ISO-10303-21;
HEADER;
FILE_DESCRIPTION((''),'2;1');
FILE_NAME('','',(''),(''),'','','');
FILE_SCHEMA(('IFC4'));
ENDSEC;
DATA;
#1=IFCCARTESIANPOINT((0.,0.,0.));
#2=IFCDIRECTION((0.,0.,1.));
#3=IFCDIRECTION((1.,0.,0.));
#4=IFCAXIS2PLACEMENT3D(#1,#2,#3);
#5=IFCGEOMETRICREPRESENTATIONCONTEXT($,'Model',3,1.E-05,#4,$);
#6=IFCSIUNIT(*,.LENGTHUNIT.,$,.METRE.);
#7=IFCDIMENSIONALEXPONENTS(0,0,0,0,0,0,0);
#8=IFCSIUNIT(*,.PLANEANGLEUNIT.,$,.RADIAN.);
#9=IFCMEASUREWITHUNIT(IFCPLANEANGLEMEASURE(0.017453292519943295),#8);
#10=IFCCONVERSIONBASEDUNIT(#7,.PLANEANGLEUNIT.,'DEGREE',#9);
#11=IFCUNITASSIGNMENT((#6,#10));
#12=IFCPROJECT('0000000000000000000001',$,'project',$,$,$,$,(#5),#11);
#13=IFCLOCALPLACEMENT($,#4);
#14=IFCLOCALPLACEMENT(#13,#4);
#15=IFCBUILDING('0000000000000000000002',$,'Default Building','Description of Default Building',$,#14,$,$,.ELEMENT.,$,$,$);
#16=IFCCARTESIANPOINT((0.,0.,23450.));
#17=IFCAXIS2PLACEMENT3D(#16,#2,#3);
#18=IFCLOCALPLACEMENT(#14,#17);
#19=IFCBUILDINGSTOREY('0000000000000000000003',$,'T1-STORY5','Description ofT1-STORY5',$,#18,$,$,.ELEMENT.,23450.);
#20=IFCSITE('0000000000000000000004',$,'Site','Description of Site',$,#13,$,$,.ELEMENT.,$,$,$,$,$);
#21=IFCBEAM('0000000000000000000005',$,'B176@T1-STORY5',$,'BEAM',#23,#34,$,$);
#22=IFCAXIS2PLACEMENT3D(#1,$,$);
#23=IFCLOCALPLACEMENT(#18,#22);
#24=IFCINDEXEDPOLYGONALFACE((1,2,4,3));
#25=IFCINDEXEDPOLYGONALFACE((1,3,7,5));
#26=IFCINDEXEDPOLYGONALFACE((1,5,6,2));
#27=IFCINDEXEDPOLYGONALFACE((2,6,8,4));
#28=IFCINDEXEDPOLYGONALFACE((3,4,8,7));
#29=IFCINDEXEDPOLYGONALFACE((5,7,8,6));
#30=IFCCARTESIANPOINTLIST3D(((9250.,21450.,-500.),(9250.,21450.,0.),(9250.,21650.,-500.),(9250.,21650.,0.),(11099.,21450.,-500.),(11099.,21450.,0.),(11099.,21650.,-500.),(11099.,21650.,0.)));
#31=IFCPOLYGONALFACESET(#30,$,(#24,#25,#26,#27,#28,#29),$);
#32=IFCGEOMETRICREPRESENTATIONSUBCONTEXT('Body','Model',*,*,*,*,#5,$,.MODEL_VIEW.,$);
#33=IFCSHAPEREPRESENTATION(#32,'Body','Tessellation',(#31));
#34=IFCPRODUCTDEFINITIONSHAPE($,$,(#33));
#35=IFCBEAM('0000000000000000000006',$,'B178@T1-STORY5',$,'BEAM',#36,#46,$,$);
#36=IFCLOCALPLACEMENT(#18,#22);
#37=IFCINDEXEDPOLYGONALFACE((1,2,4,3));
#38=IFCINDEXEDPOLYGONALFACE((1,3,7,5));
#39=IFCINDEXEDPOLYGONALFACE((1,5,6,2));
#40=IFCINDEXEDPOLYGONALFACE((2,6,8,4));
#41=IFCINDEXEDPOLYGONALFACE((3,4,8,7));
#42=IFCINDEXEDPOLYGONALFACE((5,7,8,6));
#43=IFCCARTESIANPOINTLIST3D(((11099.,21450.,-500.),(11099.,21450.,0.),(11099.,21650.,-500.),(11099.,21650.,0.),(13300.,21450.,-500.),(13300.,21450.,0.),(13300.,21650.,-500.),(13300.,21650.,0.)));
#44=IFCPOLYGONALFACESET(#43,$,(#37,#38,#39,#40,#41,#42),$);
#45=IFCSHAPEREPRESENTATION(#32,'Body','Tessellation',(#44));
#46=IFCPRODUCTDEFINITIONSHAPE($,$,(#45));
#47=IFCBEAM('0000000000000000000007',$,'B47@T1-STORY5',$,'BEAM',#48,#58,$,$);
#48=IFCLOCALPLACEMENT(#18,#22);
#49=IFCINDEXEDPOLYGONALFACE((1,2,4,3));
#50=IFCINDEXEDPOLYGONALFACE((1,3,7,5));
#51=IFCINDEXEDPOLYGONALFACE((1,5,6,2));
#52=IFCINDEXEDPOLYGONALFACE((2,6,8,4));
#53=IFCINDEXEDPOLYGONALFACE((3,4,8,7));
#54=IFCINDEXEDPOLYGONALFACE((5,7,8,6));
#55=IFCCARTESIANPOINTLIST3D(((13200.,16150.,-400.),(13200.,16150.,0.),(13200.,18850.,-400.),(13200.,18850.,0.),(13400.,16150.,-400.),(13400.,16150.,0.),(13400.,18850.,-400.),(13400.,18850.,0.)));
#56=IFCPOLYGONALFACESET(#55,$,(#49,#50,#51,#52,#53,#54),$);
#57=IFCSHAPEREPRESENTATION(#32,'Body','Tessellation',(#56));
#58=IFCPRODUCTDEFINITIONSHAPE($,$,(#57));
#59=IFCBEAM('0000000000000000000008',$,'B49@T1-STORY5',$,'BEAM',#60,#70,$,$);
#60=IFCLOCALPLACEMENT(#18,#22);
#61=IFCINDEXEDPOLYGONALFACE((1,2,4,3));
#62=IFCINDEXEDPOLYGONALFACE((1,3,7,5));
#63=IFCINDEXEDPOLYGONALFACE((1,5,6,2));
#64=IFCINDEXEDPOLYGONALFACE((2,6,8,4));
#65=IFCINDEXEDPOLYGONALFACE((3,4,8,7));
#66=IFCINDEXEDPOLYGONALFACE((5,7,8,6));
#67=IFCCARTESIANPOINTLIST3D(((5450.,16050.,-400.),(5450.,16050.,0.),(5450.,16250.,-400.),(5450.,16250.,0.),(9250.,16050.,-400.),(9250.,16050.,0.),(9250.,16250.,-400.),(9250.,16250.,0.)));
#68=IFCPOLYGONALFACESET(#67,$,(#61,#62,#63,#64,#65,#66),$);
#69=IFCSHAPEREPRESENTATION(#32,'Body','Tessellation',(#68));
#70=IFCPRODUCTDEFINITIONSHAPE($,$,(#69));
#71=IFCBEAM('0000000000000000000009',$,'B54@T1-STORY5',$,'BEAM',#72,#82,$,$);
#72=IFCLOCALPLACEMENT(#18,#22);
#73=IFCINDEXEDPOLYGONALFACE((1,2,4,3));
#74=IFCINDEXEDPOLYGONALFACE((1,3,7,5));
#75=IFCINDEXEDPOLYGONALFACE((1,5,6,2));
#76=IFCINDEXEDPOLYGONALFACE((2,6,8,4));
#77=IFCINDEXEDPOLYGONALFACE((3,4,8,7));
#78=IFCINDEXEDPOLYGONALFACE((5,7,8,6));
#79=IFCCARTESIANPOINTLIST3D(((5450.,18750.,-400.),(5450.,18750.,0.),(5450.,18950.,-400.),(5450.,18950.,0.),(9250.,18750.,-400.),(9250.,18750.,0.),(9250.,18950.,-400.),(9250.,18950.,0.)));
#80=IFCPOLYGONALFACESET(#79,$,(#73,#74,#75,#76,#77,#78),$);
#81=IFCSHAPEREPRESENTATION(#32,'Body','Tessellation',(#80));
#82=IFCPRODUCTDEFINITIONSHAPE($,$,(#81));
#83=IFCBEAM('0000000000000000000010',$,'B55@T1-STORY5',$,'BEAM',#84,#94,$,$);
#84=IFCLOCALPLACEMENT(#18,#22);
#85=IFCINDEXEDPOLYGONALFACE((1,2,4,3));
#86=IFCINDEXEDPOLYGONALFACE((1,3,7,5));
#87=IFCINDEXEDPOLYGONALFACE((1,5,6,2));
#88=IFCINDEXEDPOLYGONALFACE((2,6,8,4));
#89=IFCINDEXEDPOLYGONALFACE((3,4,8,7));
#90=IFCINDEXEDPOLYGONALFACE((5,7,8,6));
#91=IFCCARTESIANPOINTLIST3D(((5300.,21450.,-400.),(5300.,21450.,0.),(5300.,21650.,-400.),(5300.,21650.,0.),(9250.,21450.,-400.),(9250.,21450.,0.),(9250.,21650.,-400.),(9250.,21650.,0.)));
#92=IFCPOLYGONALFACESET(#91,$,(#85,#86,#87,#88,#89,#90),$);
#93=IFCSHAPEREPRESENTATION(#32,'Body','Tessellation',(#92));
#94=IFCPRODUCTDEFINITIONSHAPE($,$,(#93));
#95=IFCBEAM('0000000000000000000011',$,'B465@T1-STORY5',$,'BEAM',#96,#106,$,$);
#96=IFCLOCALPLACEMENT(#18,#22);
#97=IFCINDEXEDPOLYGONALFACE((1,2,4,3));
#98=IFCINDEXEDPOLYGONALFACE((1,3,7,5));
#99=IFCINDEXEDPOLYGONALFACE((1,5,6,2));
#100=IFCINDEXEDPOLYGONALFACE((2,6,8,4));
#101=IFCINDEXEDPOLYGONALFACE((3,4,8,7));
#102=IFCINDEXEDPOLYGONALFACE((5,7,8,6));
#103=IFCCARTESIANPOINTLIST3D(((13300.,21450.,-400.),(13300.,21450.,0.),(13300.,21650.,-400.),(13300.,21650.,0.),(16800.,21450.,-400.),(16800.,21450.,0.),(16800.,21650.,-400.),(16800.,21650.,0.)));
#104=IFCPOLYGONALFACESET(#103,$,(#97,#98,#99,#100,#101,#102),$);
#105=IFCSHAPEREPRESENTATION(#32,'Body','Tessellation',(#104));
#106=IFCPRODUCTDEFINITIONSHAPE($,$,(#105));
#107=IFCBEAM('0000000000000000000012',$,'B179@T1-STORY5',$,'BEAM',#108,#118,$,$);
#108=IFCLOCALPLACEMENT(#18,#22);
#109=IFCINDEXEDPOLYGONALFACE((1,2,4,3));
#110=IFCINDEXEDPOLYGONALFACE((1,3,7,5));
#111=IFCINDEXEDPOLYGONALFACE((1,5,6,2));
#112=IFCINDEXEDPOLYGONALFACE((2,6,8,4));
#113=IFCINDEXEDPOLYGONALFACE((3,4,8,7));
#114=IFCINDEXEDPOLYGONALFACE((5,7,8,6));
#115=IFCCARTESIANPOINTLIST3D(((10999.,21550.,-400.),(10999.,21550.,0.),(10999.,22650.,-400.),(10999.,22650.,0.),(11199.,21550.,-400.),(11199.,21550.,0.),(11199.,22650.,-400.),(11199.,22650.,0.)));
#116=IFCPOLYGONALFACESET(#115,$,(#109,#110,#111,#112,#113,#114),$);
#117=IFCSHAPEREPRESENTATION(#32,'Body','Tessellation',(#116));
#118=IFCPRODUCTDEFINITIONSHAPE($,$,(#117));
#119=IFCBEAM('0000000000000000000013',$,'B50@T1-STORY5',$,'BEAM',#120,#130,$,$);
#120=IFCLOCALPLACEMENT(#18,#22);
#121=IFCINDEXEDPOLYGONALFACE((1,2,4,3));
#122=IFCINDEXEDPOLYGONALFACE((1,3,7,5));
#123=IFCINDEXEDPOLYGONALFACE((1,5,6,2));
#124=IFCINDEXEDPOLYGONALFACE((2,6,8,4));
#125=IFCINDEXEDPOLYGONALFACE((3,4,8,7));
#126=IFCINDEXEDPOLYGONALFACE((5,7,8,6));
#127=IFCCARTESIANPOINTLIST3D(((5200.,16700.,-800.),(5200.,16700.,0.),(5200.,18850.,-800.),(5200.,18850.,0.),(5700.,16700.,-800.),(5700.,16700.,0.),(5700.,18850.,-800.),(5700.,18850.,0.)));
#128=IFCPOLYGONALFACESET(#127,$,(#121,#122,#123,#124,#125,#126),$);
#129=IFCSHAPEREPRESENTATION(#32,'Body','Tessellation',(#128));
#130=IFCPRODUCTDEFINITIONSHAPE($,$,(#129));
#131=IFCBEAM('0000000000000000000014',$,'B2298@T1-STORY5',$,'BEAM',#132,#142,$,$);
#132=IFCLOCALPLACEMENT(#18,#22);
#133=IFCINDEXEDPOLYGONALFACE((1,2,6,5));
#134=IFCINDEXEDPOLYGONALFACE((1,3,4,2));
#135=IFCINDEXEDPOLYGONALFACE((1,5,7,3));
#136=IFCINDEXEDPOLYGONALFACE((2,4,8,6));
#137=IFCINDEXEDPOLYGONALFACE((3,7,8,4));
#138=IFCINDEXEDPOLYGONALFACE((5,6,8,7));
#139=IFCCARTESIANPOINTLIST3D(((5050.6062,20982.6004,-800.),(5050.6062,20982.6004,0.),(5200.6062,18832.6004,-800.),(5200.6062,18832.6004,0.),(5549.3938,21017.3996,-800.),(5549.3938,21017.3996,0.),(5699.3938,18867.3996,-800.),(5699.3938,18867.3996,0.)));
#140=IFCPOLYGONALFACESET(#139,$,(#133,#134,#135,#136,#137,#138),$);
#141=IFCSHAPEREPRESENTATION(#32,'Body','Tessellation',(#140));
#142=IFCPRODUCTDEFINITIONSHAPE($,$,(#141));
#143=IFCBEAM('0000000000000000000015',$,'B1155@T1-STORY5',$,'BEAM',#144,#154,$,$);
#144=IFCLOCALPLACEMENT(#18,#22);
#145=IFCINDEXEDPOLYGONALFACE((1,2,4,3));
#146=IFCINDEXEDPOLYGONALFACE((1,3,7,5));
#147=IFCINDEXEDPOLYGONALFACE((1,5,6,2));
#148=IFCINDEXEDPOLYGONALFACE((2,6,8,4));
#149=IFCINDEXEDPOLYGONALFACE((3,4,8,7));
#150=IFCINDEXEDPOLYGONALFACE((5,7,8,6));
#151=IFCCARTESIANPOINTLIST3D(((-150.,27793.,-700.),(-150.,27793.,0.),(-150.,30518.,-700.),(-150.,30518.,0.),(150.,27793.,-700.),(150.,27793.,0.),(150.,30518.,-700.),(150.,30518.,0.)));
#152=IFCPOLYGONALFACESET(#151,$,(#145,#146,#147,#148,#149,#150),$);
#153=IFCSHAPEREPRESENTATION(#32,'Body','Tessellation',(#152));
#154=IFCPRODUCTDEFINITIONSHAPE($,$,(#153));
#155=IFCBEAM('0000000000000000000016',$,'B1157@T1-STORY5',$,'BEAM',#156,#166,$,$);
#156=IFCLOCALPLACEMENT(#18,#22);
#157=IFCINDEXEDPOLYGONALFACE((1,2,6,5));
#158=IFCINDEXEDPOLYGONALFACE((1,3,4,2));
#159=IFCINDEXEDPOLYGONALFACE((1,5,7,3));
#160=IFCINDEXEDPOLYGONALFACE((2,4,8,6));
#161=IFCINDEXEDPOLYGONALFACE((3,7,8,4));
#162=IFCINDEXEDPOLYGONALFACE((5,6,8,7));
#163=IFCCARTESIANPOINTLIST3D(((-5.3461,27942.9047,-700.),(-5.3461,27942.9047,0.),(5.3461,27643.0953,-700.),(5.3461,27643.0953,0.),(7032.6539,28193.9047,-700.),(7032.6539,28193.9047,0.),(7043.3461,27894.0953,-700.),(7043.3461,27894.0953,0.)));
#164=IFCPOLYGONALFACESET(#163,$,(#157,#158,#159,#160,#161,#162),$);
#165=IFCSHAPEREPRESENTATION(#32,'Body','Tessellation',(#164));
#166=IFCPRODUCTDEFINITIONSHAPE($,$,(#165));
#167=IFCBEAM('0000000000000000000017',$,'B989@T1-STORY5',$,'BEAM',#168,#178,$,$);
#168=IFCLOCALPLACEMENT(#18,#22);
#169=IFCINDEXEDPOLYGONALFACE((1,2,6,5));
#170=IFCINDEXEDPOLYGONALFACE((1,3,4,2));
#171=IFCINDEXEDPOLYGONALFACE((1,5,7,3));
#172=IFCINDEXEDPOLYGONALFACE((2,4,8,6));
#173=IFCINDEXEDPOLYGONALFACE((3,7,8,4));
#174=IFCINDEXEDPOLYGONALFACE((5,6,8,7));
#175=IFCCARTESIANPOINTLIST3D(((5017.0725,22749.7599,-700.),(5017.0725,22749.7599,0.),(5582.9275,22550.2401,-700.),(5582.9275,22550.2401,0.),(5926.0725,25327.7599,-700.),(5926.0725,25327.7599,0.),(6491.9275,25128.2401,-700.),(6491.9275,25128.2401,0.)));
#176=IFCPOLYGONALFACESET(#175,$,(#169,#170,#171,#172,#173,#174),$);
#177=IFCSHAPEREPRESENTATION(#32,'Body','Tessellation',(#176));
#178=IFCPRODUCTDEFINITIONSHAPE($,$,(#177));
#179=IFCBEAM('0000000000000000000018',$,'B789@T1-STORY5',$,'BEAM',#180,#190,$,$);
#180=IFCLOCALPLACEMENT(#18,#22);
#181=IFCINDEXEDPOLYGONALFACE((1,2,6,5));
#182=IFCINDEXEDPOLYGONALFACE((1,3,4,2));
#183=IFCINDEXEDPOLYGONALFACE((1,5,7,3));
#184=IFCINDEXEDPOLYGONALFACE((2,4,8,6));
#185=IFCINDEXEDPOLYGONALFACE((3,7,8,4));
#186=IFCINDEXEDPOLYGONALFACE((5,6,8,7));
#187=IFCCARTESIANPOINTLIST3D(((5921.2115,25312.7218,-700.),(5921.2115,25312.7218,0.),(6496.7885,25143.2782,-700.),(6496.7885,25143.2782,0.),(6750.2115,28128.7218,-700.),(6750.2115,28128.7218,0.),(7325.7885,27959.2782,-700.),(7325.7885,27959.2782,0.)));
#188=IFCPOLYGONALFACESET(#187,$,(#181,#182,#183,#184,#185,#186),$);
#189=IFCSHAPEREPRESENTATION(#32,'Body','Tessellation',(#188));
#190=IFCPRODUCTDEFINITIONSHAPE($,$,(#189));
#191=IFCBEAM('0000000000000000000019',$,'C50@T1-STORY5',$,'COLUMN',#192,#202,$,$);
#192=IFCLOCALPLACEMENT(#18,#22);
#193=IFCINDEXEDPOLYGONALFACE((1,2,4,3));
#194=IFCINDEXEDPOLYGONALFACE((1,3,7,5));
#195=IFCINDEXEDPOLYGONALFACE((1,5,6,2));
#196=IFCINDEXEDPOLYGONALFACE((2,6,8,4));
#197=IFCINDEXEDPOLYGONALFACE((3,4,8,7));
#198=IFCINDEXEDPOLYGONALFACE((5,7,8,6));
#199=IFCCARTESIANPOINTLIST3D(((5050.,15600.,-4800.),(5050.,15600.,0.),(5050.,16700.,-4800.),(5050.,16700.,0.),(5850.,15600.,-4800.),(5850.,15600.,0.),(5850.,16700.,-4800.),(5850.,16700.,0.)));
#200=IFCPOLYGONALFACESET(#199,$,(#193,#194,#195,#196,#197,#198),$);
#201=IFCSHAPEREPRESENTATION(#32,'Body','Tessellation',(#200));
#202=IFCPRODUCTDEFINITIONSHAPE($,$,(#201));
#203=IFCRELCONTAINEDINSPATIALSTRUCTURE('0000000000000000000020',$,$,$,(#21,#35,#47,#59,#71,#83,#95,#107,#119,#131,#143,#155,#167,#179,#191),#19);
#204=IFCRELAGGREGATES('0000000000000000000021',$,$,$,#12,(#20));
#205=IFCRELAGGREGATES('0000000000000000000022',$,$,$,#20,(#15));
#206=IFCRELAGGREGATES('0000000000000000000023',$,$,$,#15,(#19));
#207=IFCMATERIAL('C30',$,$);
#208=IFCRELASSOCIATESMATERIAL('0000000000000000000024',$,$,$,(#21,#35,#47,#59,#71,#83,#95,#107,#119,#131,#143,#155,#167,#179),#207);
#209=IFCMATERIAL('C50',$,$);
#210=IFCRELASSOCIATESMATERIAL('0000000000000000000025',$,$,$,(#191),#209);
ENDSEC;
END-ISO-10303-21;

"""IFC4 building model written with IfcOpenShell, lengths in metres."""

from ifc_helpers import new_model, entity, si_unit, converted_unit, frame, origin_with_axes, place, context, subcontext, project, spatial, rectangle, extrude, material, element, save


model = new_model("IFC4")

# Units and contexts
model_context = context("Model", 3, precision=1e-05, world=origin_with_axes())
body_context = subcontext(model_context, "Body", "Model", "MODEL_VIEW")
ifc_project = project(units=[si_unit("LENGTHUNIT", "METRE"), converted_unit("PLANEANGLEUNIT", "DEGREE", entity("IfcPlaneAngleMeasure", 0.017453292519943295), si_unit("PLANEANGLEUNIT", "RADIAN"), dimensions=[0, 0, 0, 0, 0, 0, 0])], contexts=[model_context])

# Site, building, storey
site_placement = place(None, origin_with_axes())
site = spatial("IfcSite", under=ifc_project, at=site_placement, Name="Site", Description="Description of Site", CompositionType="ELEMENT")
building_placement = place(site_placement, origin_with_axes())
building = spatial("IfcBuilding", under=site, at=building_placement, Name="Default Building", Description="Description of Default Building", CompositionType="ELEMENT")
storey_placement = place(building_placement, frame((0.0, 0.0, 23450.0), z_axis=(0.0, 0.0, 1.0), x_axis=(1.0, 0.0, 0.0)))
storey = spatial("IfcBuildingStorey", under=building, at=storey_placement, Name="T1-STORY5", Description="Description ofT1-STORY5", CompositionType="ELEMENT", Elevation=23450.0)

# Beams
ifc_material_1 = material(Name="C30")
beam_1_placement = place(storey_placement, frame((9250.0, 21550.0, -250.0), z_axis=(1.0, 0.0, 0.0), x_axis=(0.0, 1.0, 0.0)))
element("IfcBeam", 1, at=beam_1_placement, inside=storey, material=ifc_material_1, Name="B176@T1-STORY5", ObjectType="BEAM", context=body_context, shape_type="SweptSolid", body=[
    extrude(rectangle(XDim=200.0, YDim=500.0), origin_with_axes(), (0.0, 0.0, 1.0), 1849.0),
])
beam_2_placement = place(storey_placement, frame((11099.0, 21550.0, -250.0), z_axis=(1.0, 0.0, 0.0), x_axis=(0.0, 1.0, 0.0)))
element("IfcBeam", 2, at=beam_2_placement, inside=storey, material=ifc_material_1, Name="B178@T1-STORY5", ObjectType="BEAM", context=body_context, shape_type="SweptSolid", body=[
    extrude(rectangle(XDim=200.0, YDim=500.0), origin_with_axes(), (0.0, 0.0, 1.0), 2201.0),
])
beam_3_placement = place(storey_placement, frame((13300.0, 16150.0, -200.0), z_axis=(0.0, 1.0, 0.0), x_axis=(-1.0, 0.0, 0.0)))
element("IfcBeam", 3, at=beam_3_placement, inside=storey, material=ifc_material_1, Name="B47@T1-STORY5", ObjectType="BEAM", context=body_context, shape_type="SweptSolid", body=[
    extrude(rectangle(XDim=200.0, YDim=400.0), origin_with_axes(), (0.0, 0.0, 1.0), 2700.0),
])
for number, where, z_axis, x_axis, name in (
    (4, (5450.0, 16150.0, -200.0), (1.0, 0.0, 0.0), (0.0, 1.0, 0.0), "B49@T1-STORY5"),
    (5, (5450.0, 18850.0, -200.0), (1.0, 0.0, 0.0), (0.0, 1.0, 0.0), "B54@T1-STORY5"),
):
    element("IfcBeam", number, at=place(storey_placement, frame(where, z_axis=z_axis, x_axis=x_axis)), inside=storey, material=ifc_material_1, Name=name, ObjectType="BEAM", context=body_context, shape_type="SweptSolid", body=[
        extrude(rectangle(XDim=200.0, YDim=400.0), origin_with_axes(), (0.0, 0.0, 1.0), 3800.0),
    ])
beam_4_placement = place(storey_placement, frame((5300.0, 21550.0, -200.0), z_axis=(1.0, 0.0, 0.0), x_axis=(0.0, 1.0, 0.0)))
element("IfcBeam", 6, at=beam_4_placement, inside=storey, material=ifc_material_1, Name="B55@T1-STORY5", ObjectType="BEAM", context=body_context, shape_type="SweptSolid", body=[
    extrude(rectangle(XDim=200.0, YDim=400.0), origin_with_axes(), (0.0, 0.0, 1.0), 3950.0),
])
beam_5_placement = place(storey_placement, frame((13300.0, 21550.0, -200.0), z_axis=(1.0, 0.0, 0.0), x_axis=(0.0, 1.0, 0.0)))
element("IfcBeam", 7, at=beam_5_placement, inside=storey, material=ifc_material_1, Name="B465@T1-STORY5", ObjectType="BEAM", context=body_context, shape_type="SweptSolid", body=[
    extrude(rectangle(XDim=200.0, YDim=400.0), origin_with_axes(), (0.0, 0.0, 1.0), 3500.0),
])
beam_6_placement = place(storey_placement, frame((11099.0, 21550.0, -200.0), z_axis=(0.0, 1.0, 0.0), x_axis=(-1.0, 0.0, 0.0)))
element("IfcBeam", 8, at=beam_6_placement, inside=storey, material=ifc_material_1, Name="B179@T1-STORY5", ObjectType="BEAM", context=body_context, shape_type="SweptSolid", body=[
    extrude(rectangle(XDim=200.0, YDim=400.0), origin_with_axes(), (0.0, 0.0, 1.0), 1100.0),
])
beam_7_placement = place(storey_placement, frame((5450.0, 16700.0, -400.0), z_axis=(0.0, 1.0, 0.0), x_axis=(-1.0, 0.0, 0.0)))
element("IfcBeam", 9, at=beam_7_placement, inside=storey, material=ifc_material_1, Name="B50@T1-STORY5", ObjectType="BEAM", context=body_context, shape_type="SweptSolid", body=[
    extrude(rectangle(XDim=500.0, YDim=800.0), origin_with_axes(), (0.0, 0.0, 1.0), 2150.0),
])
beam_8_placement = place(storey_placement, frame((5300.0, 21000.0, -400.0), z_axis=(0.069598, -0.997575, 0.0), x_axis=(0.997575, 0.069598, 0.0)))
element("IfcBeam", 10, at=beam_8_placement, inside=storey, material=ifc_material_1, Name="B2298@T1-STORY5", ObjectType="BEAM", context=body_context, shape_type="SweptSolid", body=[
    extrude(rectangle(XDim=500.0, YDim=800.0), origin_with_axes(), (0.0, 0.0, 1.0), 2155.2262),
])
beam_9_placement = place(storey_placement, frame((0.0, 27793.0, -350.0), z_axis=(0.0, 1.0, 0.0), x_axis=(-1.0, 0.0, 0.0)))
element("IfcBeam", 11, at=beam_9_placement, inside=storey, material=ifc_material_1, Name="B1155@T1-STORY5", ObjectType="BEAM", context=body_context, shape_type="SweptSolid", body=[
    extrude(rectangle(XDim=300.0, YDim=700.0), origin_with_axes(), (0.0, 0.0, 1.0), 2725.0),
])
beam_10_placement = place(storey_placement, frame((0.0, 27793.0, -350.0), z_axis=(0.999365, 0.035641, 0.0), x_axis=(-0.035641, 0.999365, 0.0)))
element("IfcBeam", 12, at=beam_10_placement, inside=storey, material=ifc_material_1, Name="B1157@T1-STORY5", ObjectType="BEAM", context=body_context, shape_type="SweptSolid", body=[
    extrude(rectangle(XDim=300.0, YDim=700.0), origin_with_axes(), (0.0, 0.0, 1.0), 7042.4744),
])
beam_11_placement = place(storey_placement, frame((5300.0, 22650.0, -350.0), z_axis=(0.332533, 0.943092, 0.0), x_axis=(-0.943092, 0.332533, 0.0)))
element("IfcBeam", 13, at=beam_11_placement, inside=storey, material=ifc_material_1, Name="B989@T1-STORY5", ObjectType="BEAM", context=body_context, shape_type="SweptSolid", body=[
    extrude(rectangle(XDim=600.0, YDim=700.0), origin_with_axes(), (0.0, 0.0, 1.0), 2733.5627),
])
beam_12_placement = place(storey_placement, frame((6209.0, 25228.0, -350.0), z_axis=(0.282406, 0.959295, 0.0), x_axis=(-0.959295, 0.282406, 0.0)))
element("IfcBeam", 14, at=beam_12_placement, inside=storey, material=ifc_material_1, Name="B789@T1-STORY5", ObjectType="BEAM", context=body_context, shape_type="SweptSolid", body=[
    extrude(rectangle(XDim=600.0, YDim=700.0), origin_with_axes(), (0.0, 0.0, 1.0), 2935.4892),
])
ifc_material_2 = material(Name="C50")
beam_13_placement = place(storey_placement, frame((5450.0, 16150.0, -4800.0), z_axis=(0.0, 0.0, 1.0), x_axis=(0.0, -1.0, 0.0)))
element("IfcBeam", 15, at=beam_13_placement, inside=storey, material=ifc_material_2, Name="C50@T1-STORY5", ObjectType="COLUMN", context=body_context, shape_type="SweptSolid", body=[
    extrude(rectangle(XDim=1100.0, YDim=800.0), origin_with_axes(), (0.0, 0.0, 1.0), 4800.0),
])

save(model, "model.ifc")
